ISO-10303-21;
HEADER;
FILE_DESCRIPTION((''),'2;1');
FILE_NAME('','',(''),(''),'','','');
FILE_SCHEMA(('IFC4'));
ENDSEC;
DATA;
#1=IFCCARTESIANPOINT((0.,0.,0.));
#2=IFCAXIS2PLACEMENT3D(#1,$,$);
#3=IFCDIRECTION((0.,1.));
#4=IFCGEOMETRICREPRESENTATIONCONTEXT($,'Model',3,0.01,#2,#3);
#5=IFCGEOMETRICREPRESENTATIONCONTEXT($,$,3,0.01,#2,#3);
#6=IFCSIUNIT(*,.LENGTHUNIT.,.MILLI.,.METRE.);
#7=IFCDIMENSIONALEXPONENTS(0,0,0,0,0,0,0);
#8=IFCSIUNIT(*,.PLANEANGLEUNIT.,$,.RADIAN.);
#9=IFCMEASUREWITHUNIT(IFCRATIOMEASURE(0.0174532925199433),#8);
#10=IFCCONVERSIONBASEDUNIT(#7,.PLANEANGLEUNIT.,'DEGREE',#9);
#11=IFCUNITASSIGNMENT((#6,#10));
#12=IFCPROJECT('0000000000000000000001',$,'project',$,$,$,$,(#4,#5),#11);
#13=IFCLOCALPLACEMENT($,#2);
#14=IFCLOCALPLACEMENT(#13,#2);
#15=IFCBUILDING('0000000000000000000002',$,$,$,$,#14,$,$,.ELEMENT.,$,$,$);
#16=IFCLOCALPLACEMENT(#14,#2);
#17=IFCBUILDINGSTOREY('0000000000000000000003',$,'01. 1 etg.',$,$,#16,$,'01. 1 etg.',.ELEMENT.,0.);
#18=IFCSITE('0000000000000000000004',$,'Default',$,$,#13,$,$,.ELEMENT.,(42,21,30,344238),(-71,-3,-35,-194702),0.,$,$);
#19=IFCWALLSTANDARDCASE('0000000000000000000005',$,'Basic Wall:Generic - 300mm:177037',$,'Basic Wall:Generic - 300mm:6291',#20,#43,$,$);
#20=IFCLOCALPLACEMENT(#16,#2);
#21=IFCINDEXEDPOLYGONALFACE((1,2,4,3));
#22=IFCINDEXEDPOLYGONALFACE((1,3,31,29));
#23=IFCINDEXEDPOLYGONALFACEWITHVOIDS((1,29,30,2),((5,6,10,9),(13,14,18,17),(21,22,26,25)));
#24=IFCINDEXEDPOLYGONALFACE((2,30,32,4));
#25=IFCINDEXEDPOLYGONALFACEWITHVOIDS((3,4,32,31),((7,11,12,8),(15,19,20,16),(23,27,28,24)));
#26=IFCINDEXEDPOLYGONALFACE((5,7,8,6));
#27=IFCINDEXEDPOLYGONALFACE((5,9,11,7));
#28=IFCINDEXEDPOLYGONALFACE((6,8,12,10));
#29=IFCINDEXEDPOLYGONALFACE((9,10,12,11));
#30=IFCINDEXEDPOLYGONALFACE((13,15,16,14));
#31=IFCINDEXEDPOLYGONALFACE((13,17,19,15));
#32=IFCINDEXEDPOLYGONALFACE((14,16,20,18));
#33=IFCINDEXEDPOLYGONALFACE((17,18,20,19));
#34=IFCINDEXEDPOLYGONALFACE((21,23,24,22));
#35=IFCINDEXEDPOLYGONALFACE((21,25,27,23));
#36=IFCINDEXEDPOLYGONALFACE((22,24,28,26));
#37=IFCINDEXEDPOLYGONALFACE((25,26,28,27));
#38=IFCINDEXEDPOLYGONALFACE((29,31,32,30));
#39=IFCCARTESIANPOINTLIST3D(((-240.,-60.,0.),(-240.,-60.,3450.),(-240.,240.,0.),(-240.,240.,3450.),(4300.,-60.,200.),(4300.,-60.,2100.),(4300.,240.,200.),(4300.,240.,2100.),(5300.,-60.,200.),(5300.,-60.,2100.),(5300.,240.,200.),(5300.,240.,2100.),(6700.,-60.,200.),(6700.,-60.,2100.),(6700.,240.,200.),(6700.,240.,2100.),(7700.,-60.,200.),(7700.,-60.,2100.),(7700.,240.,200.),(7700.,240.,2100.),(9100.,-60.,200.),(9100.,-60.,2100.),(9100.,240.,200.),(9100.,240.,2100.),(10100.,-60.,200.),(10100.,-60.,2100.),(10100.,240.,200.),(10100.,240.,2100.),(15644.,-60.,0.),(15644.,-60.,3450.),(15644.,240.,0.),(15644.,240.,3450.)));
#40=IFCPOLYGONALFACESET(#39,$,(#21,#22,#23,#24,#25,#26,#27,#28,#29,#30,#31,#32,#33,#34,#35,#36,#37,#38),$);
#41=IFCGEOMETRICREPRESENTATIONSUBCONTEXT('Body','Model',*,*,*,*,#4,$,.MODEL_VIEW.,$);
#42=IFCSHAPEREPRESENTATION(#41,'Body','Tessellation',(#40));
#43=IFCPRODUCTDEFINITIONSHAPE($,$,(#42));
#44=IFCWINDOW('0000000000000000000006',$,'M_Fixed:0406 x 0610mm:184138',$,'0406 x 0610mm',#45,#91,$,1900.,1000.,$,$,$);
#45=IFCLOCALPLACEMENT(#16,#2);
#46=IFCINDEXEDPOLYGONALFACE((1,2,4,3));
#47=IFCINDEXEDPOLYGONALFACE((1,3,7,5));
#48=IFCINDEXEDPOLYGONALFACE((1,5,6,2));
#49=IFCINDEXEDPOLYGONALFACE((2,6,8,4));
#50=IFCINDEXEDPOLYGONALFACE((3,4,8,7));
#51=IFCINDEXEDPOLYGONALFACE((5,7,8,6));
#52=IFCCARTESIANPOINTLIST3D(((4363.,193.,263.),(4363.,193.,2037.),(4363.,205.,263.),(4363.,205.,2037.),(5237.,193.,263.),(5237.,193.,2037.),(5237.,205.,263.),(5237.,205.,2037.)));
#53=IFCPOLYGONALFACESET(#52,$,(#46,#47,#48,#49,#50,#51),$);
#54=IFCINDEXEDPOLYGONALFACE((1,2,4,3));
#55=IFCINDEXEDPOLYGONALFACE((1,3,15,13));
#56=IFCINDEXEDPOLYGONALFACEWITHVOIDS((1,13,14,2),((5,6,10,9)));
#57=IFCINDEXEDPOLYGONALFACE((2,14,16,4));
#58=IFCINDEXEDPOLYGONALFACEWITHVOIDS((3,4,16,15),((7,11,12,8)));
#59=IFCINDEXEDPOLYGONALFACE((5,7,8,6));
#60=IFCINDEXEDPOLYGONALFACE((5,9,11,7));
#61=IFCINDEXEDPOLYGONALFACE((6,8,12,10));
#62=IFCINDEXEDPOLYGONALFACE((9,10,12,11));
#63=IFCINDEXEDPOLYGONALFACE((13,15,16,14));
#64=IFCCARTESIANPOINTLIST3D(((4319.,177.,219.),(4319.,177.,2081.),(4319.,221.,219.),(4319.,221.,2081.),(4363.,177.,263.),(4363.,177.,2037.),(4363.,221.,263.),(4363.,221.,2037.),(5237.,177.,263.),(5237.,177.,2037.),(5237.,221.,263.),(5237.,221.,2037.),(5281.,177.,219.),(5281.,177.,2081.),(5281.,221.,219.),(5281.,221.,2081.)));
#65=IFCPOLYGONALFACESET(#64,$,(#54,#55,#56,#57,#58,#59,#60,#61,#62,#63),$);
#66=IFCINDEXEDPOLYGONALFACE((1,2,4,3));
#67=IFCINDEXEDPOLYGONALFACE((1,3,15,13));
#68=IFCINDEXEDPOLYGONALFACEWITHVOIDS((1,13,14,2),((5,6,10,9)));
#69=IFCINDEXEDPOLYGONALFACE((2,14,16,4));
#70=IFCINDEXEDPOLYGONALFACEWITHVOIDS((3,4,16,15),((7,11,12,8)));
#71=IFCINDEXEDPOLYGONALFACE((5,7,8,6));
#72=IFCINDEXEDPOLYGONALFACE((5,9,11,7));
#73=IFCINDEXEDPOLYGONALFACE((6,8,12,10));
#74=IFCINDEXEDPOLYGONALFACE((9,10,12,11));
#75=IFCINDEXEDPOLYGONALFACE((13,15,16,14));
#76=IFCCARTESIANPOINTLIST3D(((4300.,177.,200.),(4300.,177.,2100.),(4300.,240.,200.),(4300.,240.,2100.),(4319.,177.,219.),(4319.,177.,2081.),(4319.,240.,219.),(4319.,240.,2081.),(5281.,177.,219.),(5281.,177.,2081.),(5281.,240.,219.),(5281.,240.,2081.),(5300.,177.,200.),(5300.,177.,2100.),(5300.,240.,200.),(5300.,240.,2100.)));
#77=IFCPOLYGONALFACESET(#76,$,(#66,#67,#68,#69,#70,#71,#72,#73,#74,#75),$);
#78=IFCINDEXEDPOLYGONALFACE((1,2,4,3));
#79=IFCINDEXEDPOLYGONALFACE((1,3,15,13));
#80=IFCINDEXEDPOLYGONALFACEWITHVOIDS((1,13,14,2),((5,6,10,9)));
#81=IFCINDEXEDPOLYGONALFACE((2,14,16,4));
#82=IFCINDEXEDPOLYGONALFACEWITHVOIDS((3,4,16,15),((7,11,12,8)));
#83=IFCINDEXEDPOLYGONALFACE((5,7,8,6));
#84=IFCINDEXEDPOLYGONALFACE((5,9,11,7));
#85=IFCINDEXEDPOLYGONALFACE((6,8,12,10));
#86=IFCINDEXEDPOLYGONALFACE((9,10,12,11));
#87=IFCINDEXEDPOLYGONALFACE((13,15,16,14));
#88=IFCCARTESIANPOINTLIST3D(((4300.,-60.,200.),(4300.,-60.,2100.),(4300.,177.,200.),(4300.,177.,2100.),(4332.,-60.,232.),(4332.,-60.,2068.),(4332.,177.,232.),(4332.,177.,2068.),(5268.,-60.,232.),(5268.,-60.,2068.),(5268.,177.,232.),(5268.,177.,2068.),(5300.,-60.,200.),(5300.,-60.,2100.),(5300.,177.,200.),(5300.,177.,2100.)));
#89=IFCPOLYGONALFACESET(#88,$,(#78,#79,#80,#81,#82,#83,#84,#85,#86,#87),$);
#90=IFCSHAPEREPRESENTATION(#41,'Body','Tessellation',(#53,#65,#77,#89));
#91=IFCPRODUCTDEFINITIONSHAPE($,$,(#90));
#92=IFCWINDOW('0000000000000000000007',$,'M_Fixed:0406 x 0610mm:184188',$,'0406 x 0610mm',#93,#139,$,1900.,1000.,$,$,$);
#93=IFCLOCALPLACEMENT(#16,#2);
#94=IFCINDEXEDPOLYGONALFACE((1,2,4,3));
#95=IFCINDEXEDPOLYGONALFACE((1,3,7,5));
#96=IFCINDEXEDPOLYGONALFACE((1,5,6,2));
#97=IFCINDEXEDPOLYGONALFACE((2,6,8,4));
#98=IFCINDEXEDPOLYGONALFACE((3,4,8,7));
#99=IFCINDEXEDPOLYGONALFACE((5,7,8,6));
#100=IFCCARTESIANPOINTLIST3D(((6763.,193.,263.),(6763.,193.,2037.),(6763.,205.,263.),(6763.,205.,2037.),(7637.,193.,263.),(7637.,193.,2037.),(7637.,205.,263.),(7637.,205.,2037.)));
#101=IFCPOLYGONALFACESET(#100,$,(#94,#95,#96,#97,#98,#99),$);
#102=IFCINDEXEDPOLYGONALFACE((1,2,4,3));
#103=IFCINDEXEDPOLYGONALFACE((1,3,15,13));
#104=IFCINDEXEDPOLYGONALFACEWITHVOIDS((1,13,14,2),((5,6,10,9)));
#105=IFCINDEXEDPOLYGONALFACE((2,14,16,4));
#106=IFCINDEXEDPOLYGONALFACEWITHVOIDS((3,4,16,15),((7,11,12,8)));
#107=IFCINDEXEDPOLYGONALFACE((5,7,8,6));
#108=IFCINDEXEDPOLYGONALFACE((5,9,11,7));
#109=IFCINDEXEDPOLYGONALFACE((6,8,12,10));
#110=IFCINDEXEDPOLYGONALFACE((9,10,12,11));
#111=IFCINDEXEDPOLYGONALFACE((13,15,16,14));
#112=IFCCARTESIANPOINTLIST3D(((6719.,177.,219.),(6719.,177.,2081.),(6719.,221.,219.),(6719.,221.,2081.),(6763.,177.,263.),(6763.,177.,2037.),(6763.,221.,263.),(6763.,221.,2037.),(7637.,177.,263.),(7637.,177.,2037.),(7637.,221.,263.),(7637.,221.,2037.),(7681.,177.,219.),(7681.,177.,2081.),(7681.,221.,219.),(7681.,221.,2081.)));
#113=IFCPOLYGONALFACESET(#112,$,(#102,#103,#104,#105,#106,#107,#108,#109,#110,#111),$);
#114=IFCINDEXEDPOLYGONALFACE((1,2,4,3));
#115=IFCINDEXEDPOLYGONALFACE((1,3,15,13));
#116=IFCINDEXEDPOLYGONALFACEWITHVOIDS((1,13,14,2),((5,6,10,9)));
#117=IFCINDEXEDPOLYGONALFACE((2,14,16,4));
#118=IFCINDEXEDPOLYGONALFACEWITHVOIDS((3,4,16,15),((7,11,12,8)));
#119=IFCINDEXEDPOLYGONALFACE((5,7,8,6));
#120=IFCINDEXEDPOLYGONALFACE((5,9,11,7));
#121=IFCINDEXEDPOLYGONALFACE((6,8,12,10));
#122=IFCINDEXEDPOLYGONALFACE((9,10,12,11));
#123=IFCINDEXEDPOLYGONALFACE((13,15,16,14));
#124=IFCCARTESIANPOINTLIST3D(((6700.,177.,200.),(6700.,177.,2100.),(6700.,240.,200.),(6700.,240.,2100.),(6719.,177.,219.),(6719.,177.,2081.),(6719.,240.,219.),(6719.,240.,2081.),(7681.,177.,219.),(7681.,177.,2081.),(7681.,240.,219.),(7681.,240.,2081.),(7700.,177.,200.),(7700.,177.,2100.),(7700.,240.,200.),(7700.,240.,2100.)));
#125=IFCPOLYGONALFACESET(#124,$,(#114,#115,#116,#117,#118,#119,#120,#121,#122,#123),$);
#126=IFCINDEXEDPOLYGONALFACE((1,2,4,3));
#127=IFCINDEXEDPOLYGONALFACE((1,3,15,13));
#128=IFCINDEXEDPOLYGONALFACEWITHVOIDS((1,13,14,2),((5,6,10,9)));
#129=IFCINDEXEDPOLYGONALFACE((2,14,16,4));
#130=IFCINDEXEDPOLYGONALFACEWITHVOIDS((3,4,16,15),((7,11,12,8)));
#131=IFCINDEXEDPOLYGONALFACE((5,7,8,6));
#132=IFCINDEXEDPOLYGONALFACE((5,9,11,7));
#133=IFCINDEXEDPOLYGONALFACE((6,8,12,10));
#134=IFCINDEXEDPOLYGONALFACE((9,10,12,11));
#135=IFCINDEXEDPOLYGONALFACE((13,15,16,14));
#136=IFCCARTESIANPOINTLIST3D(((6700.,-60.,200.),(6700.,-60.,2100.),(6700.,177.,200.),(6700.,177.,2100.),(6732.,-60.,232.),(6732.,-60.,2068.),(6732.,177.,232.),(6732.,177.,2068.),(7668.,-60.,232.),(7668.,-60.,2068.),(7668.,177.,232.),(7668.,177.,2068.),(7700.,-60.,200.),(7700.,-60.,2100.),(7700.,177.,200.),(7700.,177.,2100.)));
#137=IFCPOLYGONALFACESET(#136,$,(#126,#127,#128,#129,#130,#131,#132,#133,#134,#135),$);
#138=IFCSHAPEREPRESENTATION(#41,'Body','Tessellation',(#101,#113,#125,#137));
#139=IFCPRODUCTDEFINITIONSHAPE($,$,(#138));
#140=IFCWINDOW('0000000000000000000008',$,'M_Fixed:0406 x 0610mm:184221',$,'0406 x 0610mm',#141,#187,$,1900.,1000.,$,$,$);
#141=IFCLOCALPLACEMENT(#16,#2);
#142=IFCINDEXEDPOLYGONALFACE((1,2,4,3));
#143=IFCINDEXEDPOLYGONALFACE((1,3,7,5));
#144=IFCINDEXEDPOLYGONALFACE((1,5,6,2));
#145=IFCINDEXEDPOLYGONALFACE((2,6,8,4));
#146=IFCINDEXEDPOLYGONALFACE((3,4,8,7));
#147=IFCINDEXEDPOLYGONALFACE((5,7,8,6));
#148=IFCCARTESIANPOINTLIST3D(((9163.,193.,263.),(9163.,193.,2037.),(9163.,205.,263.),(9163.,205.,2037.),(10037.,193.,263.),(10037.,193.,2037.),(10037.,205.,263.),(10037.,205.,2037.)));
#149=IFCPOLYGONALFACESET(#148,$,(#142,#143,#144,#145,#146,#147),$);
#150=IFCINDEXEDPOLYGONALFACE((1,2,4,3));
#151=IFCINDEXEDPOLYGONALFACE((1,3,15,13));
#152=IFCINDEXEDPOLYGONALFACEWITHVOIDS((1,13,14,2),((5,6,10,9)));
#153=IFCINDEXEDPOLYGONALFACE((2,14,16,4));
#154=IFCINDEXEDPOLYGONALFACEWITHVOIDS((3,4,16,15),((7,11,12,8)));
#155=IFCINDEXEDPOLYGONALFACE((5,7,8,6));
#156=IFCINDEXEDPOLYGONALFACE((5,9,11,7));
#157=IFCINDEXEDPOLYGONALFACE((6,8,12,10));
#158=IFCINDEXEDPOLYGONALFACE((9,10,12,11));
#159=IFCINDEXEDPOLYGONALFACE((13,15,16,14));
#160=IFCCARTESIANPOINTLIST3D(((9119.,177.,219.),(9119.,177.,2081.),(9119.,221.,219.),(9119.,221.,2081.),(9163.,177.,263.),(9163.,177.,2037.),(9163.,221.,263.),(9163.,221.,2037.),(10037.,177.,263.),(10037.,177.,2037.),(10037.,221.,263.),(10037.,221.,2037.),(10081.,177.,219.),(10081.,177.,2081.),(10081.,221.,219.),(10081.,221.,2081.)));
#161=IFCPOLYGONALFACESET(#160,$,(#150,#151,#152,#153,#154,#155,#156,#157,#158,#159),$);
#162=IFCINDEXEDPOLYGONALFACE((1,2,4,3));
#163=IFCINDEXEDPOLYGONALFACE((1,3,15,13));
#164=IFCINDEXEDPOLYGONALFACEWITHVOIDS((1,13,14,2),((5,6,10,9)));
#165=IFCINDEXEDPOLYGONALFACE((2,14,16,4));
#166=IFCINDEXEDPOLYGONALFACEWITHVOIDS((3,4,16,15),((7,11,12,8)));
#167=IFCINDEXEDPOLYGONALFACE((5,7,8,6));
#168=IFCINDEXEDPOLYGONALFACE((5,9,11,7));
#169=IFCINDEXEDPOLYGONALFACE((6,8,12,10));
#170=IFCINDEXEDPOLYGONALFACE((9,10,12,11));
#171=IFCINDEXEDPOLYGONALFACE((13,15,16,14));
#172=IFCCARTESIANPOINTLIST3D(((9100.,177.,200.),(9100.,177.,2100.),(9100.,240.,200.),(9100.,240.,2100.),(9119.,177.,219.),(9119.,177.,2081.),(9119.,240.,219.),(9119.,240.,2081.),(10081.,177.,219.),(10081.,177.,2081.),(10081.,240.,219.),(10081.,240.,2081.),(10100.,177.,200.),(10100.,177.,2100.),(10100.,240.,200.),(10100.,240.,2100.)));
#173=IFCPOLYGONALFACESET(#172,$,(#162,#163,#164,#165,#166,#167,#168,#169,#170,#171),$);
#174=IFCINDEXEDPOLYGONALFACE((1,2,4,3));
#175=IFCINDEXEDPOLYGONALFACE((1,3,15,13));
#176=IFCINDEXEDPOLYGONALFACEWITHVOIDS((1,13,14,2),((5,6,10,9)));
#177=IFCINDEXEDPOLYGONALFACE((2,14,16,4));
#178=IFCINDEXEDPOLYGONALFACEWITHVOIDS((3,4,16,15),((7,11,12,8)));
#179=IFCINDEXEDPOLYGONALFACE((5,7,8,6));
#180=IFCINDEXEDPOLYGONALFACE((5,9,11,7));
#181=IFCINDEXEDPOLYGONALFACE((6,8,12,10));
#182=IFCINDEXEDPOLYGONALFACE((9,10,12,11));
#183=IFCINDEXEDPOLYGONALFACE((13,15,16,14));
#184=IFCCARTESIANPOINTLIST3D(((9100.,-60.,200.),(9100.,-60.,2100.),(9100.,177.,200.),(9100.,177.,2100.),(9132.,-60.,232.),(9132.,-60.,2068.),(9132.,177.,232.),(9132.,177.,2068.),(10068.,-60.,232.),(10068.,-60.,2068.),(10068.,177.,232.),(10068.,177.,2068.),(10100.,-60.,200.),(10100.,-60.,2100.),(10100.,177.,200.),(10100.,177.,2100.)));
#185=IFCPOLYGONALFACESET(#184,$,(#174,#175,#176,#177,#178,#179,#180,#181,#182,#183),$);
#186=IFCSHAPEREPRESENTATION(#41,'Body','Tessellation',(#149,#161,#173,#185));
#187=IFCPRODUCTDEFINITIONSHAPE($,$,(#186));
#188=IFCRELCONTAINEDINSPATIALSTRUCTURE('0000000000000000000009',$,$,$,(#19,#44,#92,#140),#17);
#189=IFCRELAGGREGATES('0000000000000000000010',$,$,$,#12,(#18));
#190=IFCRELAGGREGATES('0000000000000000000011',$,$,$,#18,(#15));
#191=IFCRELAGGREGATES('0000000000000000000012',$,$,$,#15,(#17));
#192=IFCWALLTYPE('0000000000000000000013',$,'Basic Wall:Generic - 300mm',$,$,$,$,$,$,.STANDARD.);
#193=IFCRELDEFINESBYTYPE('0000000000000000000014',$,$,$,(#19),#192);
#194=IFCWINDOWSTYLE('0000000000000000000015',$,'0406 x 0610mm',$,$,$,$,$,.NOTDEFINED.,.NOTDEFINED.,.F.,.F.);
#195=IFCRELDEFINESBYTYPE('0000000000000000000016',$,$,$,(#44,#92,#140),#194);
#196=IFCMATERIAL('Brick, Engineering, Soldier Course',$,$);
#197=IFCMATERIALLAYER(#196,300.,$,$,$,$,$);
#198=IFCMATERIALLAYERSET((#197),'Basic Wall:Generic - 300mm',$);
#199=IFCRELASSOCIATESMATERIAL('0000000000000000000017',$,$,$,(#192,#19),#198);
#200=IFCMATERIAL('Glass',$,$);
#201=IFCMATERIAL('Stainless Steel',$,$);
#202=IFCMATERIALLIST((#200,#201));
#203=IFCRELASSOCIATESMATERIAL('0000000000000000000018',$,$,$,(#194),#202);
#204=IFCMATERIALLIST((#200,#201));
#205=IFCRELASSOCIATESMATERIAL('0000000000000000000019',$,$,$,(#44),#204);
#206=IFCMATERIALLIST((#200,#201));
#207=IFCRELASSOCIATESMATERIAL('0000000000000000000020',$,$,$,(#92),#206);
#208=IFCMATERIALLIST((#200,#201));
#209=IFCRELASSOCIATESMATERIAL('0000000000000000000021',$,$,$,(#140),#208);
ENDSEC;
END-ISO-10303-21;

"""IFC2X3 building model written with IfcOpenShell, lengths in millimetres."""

from ifc_helpers import new_model, entity, si_unit, converted_unit, direction, frame, frame_2d, origin, place, context, subcontext, project, spatial, polyline, rectangle, outline, extrude, clip, bounded_halfspace, source, transform, mapped, material, material_list, layer, layer_set, layer_usage, type_object, type_shapes, element, fill, save


model = new_model("IFC2X3")

# Units and contexts
model_context = context("Model", 3, precision=0.01, world=origin(), true_north=direction((0.0, 1.0)))
context_of_model = context(None, 3, precision=0.01, world=origin(), true_north=direction((0.0, 1.0)))
body_context = subcontext(model_context, "Body", "Model", "MODEL_VIEW")
ifc_project = project(units=[si_unit("LENGTHUNIT", "METRE", prefix="MILLI"), converted_unit("PLANEANGLEUNIT", "DEGREE", entity("IfcRatioMeasure", 0.0174532925199433), si_unit("PLANEANGLEUNIT", "RADIAN"), dimensions=[0, 0, 0, 0, 0, 0, 0])], contexts=[model_context, context_of_model])

# Site, building, storey
site_placement = place(None, origin())
site = spatial("IfcSite", under=ifc_project, at=site_placement, Name="Default", CompositionType="ELEMENT", RefLatitude=(42, 21, 30, 344238), RefLongitude=(-71, -3, -35, -194702), RefElevation=0.0)
building_placement = place(site_placement, origin())
building = spatial("IfcBuilding", under=site, at=building_placement, CompositionType="ELEMENT")
storey_placement = place(building_placement, origin())
storey = spatial("IfcBuildingStorey", under=building, at=storey_placement, Name="01. 1 etg.", LongName="01. 1 etg.", CompositionType="ELEMENT", Elevation=0.0)

# Wall, openings, windows
ifc_material_1 = material(Name="Brick, Engineering, Soldier Course")
ifc_layer_1 = layer(ifc_material_1, 300.0)
ifc_layer_set_1 = layer_set([ifc_layer_1], Name="Basic Wall:Generic - 300mm")
ifc_layer_usage_1 = layer_usage(ifc_layer_set_1, "AXIS2", "POSITIVE", -150.0)
wall_type_1 = type_object("IfcWallType", Name="Basic Wall:Generic - 300mm", PredefinedType="STANDARD", material=ifc_layer_set_1)
wall_1_placement = place(storey_placement, frame((15644.0, 90.0, 0.0), z_axis=(0.0, 0.0, 1.0), x_axis=(-1.0, 0.0, 0.0)))
wall_1 = element("IfcWallStandardCase", 1, at=wall_1_placement, inside=storey, type_object=wall_type_1, material=ifc_layer_usage_1, Name="Basic Wall:Generic - 300mm:177037", ObjectType="Basic Wall:Generic - 300mm:6291", context=body_context, shape_type="Clipping", body=[
    clip(extrude(rectangle(XDim=15884.0, YDim=300.0, at=frame_2d((7942.0, 0.0), x_axis=(-1.0, 0.0))), origin(), (0.0, 0.0, 1.0), 3450.0), bounded_halfspace(frame((15834.0, -100.0, 3450.0), z_axis=(0.0, 0.0, -1.0), x_axis=(0.0, 1.0, 0.0)), True, frame((15834.0, -100.0, 3450.0)), polyline([(0.0, 0.0), (0.0, 250.0), (-250.0, 250.0), (-3740.0, 250.0), (-3840.0, 250.0), (-6140.0, 250.0), (-6240.0, 250.0), (-8540.0, 250.0), (-8640.0, 250.0), (-10940.0, 250.0), (-11040.0, 250.0), (-15534.0, 250.0), (-15780.0, 250.0), (-15780.0, 0.0), (0.0, 0.0)]))),
])
opening_1_placement = place(wall_1_placement, frame((11344.0, 150.0, 200.0)))
opening_1 = element("IfcOpeningElement", 2, at=opening_1_placement, cuts=wall_1, ObjectType="Opening", context=body_context, shape_type="SweptSolid", body=[
    extrude(rectangle(XDim=1900.0, YDim=1000.0, at=frame_2d((950.0, 500.0), x_axis=(1.0, 0.0))), frame((0.0, 0.0, 0.0), z_axis=(0.0, -1.0, 0.0), x_axis=(0.0, 0.0, 1.0)), (0.0, 0.0, 1.0), 300.0),
])
opening_2_placement = place(wall_1_placement, frame((8944.0, 150.0, 200.0)))
opening_2 = element("IfcOpeningElement", 3, at=opening_2_placement, cuts=wall_1, ObjectType="Opening", context=body_context, shape_type="SweptSolid", body=[
    extrude(rectangle(XDim=1900.0, YDim=1000.0, at=frame_2d((950.0, 500.0), x_axis=(1.0, 0.0))), frame((0.0, 0.0, 0.0), z_axis=(0.0, -1.0, 0.0), x_axis=(0.0, 0.0, 1.0)), (0.0, 0.0, 1.0), 300.0),
])
opening_3_placement = place(wall_1_placement, frame((6544.0, 150.0, 200.0)))
opening_3 = element("IfcOpeningElement", 4, at=opening_3_placement, cuts=wall_1, ObjectType="Opening", context=body_context, shape_type="SweptSolid", body=[
    extrude(rectangle(XDim=1900.0, YDim=1000.0, at=frame_2d((950.0, 500.0), x_axis=(1.0, 0.0))), frame((0.0, 0.0, 0.0), z_axis=(0.0, -1.0, 0.0), x_axis=(0.0, 0.0, 1.0)), (0.0, 0.0, 1.0), 300.0),
])
ifc_material_2 = material(Name="Glass")
ifc_material_3 = material(Name="Stainless Steel")
ifc_material_list_1 = material_list([ifc_material_2, ifc_material_3])
ifc_material_list_2 = material_list([ifc_material_2, ifc_material_3])
window_style_1 = type_object("IfcWindowStyle", Name="0406 x 0610mm", ConstructionType="NOTDEFINED", OperationType="NOTDEFINED", ParameterTakesPrecedence=False, Sizeable=False, material=ifc_material_list_2)
shared_shape_1 = source(origin(), body_context, "Body", "SweptSolid", [
    extrude(rectangle(XDim=12.0, YDim=874.0, at=frame_2d((0.0, 0.0), x_axis=(1.0, 0.0))), frame((500.0, 259.0, 63.0), z_axis=(0.0, 0.0, 1.0), x_axis=(0.0, -1.0, 0.0)), (0.0, 0.0, 1.0), 1774.0),
    extrude(outline(polyline([(-481.0, -931.0), (481.0, -931.0), (481.0, 931.0), (-481.0, 931.0), (-481.0, -931.0)]), holes=[polyline([(-437.0, -887.0), (-437.0, 887.0), (437.0, 887.0), (437.0, -887.0), (-437.0, -887.0)])]), frame((500.0, 237.0, 950.0), z_axis=(0.0, 1.0, 0.0), x_axis=(1.0, 0.0, 0.0)), (0.0, 0.0, 1.0), 44.0),
    extrude(outline(polyline([(-500.0, -950.0), (500.0, -950.0), (500.0, 950.0), (-500.0, 950.0), (-500.0, -950.0)]), holes=[polyline([(-481.0, -931.0), (-481.0, 931.0), (481.0, 931.0), (481.0, -931.0), (-481.0, -931.0)])]), frame((500.0, 237.0, 950.0), z_axis=(0.0, 1.0, 0.0), x_axis=(1.0, 0.0, 0.0)), (0.0, 0.0, 1.0), 63.0),
    extrude(outline(polyline([(-500.0, -950.0), (500.0, -950.0), (500.0, 950.0), (-500.0, 950.0), (-500.0, -950.0)]), holes=[polyline([(-468.0, -918.0), (-468.0, 918.0), (468.0, 918.0), (468.0, -918.0), (-468.0, -918.0)])]), frame((500.0, 0.0, 950.0), z_axis=(0.0, 1.0, 0.0), x_axis=(1.0, 0.0, 0.0)), (0.0, 0.0, 1.0), 237.0),
])
type_shapes(window_style_1, [shared_shape_1])
window_1_placement = place(opening_1_placement, frame((0.0, 0.0, 0.0), z_axis=(0.0, 0.0, 1.0), x_axis=(-1.0, 0.0, 0.0)))
window_1 = element("IfcWindow", 5, at=window_1_placement, inside=storey, type_object=window_style_1, material=ifc_material_list_1, Name="M_Fixed:0406 x 0610mm:184138", ObjectType="0406 x 0610mm", OverallHeight=1900.0, OverallWidth=1000.0, context=body_context, shape_type="MappedRepresentation", body=[
    mapped(shared_shape_1, transform((0.0, 0.0, 0.0), scale=1.0)),
])
fill(opening_1, window_1)
ifc_material_list_3 = material_list([ifc_material_2, ifc_material_3])
window_2_placement = place(opening_2_placement, frame((0.0, 0.0, 0.0), z_axis=(0.0, 0.0, 1.0), x_axis=(-1.0, 0.0, 0.0)))
window_2 = element("IfcWindow", 6, at=window_2_placement, inside=storey, type_object=window_style_1, material=ifc_material_list_3, Name="M_Fixed:0406 x 0610mm:184188", ObjectType="0406 x 0610mm", OverallHeight=1900.0, OverallWidth=1000.0, context=body_context, shape_type="MappedRepresentation", body=[
    mapped(shared_shape_1, transform((0.0, 0.0, 0.0), scale=1.0)),
])
fill(opening_2, window_2)
ifc_material_list_4 = material_list([ifc_material_2, ifc_material_3])
window_3_placement = place(opening_3_placement, frame((0.0, 0.0, 0.0), z_axis=(0.0, 0.0, 1.0), x_axis=(-1.0, 0.0, 0.0)))
window_3 = element("IfcWindow", 7, at=window_3_placement, inside=storey, type_object=window_style_1, material=ifc_material_list_4, Name="M_Fixed:0406 x 0610mm:184221", ObjectType="0406 x 0610mm", OverallHeight=1900.0, OverallWidth=1000.0, context=body_context, shape_type="MappedRepresentation", body=[
    mapped(shared_shape_1, transform((0.0, 0.0, 0.0), scale=1.0)),
])
fill(opening_3, window_3)

save(model, "model.ifc")
